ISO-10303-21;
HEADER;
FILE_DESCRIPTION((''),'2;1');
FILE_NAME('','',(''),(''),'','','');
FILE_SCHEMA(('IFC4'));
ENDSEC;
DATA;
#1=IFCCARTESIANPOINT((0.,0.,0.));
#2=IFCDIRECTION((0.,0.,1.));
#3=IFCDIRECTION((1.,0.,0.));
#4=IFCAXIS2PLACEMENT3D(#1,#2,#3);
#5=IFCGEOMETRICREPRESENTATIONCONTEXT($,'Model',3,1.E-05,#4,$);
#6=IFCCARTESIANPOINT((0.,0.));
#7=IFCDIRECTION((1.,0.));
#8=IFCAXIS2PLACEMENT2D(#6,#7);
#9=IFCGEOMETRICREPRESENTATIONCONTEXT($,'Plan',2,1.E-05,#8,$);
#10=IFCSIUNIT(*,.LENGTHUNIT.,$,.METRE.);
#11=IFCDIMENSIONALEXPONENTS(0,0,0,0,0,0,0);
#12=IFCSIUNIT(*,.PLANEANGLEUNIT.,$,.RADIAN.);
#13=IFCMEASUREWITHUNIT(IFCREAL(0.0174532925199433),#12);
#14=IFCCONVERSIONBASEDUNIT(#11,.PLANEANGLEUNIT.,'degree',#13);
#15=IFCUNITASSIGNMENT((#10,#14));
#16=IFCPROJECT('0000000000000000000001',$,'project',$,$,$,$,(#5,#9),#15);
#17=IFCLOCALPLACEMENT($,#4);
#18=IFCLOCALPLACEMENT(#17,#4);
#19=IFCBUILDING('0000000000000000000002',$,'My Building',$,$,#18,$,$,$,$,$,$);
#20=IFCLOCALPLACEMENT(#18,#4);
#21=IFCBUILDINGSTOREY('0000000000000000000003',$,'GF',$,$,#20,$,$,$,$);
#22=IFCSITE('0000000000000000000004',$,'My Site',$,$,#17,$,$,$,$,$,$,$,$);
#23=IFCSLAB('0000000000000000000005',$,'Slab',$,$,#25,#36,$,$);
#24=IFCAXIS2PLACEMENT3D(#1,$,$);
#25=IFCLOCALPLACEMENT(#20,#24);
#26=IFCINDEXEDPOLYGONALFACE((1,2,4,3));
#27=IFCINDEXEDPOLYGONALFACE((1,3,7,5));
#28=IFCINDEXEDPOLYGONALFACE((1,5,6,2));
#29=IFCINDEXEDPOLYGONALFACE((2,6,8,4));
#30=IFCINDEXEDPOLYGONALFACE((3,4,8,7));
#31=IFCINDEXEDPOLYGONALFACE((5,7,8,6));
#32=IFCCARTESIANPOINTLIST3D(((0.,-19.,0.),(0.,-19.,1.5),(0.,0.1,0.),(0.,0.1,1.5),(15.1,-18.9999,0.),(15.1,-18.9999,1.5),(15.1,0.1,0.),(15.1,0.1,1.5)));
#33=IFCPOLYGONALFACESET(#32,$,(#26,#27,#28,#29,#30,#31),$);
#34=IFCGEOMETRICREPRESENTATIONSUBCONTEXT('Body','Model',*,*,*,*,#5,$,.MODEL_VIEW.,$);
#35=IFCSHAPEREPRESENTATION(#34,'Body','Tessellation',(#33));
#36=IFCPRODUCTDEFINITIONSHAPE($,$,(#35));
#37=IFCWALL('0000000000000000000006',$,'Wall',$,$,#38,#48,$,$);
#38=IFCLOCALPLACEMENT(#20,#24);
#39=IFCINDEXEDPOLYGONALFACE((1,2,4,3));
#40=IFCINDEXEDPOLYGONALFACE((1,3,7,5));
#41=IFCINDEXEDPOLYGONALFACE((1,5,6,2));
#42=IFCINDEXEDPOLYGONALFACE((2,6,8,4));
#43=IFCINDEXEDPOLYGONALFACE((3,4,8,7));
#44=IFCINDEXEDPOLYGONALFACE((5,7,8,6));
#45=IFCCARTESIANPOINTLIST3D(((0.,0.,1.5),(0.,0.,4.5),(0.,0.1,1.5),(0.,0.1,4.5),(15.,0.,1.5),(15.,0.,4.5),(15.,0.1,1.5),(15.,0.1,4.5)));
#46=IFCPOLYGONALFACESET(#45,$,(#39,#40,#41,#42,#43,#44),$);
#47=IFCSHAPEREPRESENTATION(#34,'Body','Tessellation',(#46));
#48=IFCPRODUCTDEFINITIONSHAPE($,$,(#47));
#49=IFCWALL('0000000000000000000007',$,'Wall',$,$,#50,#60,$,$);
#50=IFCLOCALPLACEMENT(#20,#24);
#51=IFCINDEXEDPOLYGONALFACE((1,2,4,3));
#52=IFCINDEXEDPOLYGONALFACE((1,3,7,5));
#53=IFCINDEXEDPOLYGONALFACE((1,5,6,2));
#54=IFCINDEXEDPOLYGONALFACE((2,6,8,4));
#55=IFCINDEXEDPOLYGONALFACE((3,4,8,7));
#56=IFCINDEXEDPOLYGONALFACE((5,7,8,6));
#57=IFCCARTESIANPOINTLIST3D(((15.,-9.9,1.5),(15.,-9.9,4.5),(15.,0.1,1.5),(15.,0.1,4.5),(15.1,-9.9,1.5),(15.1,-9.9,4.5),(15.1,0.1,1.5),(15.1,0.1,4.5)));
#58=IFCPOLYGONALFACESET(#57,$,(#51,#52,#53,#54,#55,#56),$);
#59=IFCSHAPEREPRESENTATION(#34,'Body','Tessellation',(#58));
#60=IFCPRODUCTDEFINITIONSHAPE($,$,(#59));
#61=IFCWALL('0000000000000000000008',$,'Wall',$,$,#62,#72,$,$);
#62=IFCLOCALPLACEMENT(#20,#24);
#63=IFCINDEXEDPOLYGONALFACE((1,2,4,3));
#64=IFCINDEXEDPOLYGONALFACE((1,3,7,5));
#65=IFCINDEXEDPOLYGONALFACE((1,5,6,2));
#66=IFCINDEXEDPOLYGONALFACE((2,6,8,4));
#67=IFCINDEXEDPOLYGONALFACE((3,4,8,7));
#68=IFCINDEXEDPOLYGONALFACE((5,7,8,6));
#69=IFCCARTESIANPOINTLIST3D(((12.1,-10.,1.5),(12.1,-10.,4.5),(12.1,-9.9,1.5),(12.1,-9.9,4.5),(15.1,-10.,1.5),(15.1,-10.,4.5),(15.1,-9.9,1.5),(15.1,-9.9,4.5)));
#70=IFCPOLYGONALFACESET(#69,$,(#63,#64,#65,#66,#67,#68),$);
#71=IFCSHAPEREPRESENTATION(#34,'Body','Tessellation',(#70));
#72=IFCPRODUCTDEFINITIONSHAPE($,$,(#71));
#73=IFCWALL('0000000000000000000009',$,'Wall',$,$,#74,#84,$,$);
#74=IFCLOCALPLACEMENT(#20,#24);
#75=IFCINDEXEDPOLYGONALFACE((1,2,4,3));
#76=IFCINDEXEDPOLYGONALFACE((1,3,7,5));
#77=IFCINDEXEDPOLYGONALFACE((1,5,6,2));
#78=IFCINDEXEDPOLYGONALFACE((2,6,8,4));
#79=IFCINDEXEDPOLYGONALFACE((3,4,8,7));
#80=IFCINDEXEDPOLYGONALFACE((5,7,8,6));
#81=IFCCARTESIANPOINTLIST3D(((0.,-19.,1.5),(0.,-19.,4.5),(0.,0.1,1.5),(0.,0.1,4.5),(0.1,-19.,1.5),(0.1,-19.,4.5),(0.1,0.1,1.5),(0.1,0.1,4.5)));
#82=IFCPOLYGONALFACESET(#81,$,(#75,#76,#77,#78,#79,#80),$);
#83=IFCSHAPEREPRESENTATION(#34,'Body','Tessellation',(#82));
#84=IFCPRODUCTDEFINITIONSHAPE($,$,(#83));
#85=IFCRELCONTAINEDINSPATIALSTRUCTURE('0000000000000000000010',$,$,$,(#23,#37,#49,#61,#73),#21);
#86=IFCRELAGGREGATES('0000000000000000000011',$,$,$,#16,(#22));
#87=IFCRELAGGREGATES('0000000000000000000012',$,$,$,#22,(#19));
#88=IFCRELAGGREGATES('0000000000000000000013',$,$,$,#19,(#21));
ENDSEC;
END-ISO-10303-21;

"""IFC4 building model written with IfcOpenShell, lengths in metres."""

from ifc_helpers import new_model, entity, si_unit, converted_unit, frame, origin_with_axes, origin_2d_with_axis, place, context, subcontext, project, spatial, line, indexed_curve, outline, extrude, element, save


model = new_model("IFC4")

# Units and contexts
model_context = context("Model", 3, precision=1e-05, world=origin_with_axes())
plan_context = context("Plan", 2, precision=1e-05, world=origin_2d_with_axis())
body_context_1 = subcontext(model_context, "Body", "Model", "MODEL_VIEW")
ifc_project = project(units=[si_unit("LENGTHUNIT", "METRE"), converted_unit("PLANEANGLEUNIT", "degree", entity("IfcReal", 0.0174532925199433), si_unit("PLANEANGLEUNIT", "RADIAN"), dimensions=[0, 0, 0, 0, 0, 0, 0])], contexts=[model_context, plan_context])

# Site, building, storey
site_placement = place(None, origin_with_axes())
site = spatial("IfcSite", under=ifc_project, at=site_placement, Name="My Site")
building_placement = place(site_placement, origin_with_axes())
building = spatial("IfcBuilding", under=site, at=building_placement, Name="My Building")
storey_placement = place(building_placement, origin_with_axes())
storey = spatial("IfcBuildingStorey", under=building, at=storey_placement, Name="GF")

# Slab
slab_placement = place(storey_placement, frame((0.0, 0.1, 0.1), z_axis=(0.0, 0.0, 1.0), x_axis=(1.0, 0.0, 0.0)))
element("IfcSlab", 1, at=slab_placement, inside=storey, Name="Slab", context=body_context_1, shape_type="SweptSolid", body=[
    extrude(outline(indexed_curve([(0.0, 0.0), (15.1, 0.0), (15.1, -19.0999), (0.0, -19.1), (0.0, 0.0)])), frame((0.0, 0.0, -0.1), z_axis=(0.0, 0.0, 1.0), x_axis=(1.0, 0.0, 0.0)), (0.0, 0.0, 1.0), 1.5),
])

# Walls
wall_1_placement = place(storey_placement, frame((0.0, 0.0, 1.5), z_axis=(0.0, 0.0, 1.0), x_axis=(1.0, 0.0, 0.0)))
element("IfcWall", 2, at=wall_1_placement, inside=storey, Name="Wall", context=body_context_1, shape_type="SweptSolid", body=[
    extrude(outline(indexed_curve([(0.0, 0.0), (0.0, 0.1), (15.0, 0.1), (15.0, 0.0)], segments=[line(1, 2, 3, 4, 1)])), origin_with_axes(), (0.0, 0.0, 1.0), 3.0),
])
wall_2_placement = place(storey_placement, frame((15.0, 0.1, 1.5), z_axis=(0.0, 0.0, 1.0), x_axis=(0.0, -1.0, 0.0)))
element("IfcWall", 3, at=wall_2_placement, inside=storey, Name="Wall", context=body_context_1, shape_type="SweptSolid", body=[
    extrude(outline(indexed_curve([(0.0, 0.0), (0.0, 0.1), (10.0, 0.1), (10.0, 0.0)], segments=[line(1, 2, 3, 4, 1)])), origin_with_axes(), (0.0, 0.0, 1.0), 3.0),
])
wall_3_placement = place(storey_placement, frame((15.1, -9.9, 1.5), z_axis=(0.0, 0.0, 1.0), x_axis=(-1.0, 0.0, 0.0)))
element("IfcWall", 4, at=wall_3_placement, inside=storey, Name="Wall", context=body_context_1, shape_type="SweptSolid", body=[
    extrude(outline(indexed_curve([(0.0, 0.0), (0.0, 0.1), (3.0, 0.1), (3.0, 0.0)], segments=[line(1, 2, 3, 4, 1)])), origin_with_axes(), (0.0, 0.0, 1.0), 3.0),
])
wall_4_placement = place(storey_placement, frame((0.1, -19.0, 1.5), z_axis=(0.0, 0.0, 1.0), x_axis=(0.0, 1.0, 0.0)))
element("IfcWall", 5, at=wall_4_placement, inside=storey, Name="Wall", context=body_context_1, shape_type="SweptSolid", body=[
    extrude(outline(indexed_curve([(0.0, 0.0), (0.0, 0.1), (19.1, 0.1), (19.1, 0.0)], segments=[line(1, 2, 3, 4, 1)])), origin_with_axes(), (0.0, 0.0, 1.0), 3.0),
])

save(model, "model.ifc")
